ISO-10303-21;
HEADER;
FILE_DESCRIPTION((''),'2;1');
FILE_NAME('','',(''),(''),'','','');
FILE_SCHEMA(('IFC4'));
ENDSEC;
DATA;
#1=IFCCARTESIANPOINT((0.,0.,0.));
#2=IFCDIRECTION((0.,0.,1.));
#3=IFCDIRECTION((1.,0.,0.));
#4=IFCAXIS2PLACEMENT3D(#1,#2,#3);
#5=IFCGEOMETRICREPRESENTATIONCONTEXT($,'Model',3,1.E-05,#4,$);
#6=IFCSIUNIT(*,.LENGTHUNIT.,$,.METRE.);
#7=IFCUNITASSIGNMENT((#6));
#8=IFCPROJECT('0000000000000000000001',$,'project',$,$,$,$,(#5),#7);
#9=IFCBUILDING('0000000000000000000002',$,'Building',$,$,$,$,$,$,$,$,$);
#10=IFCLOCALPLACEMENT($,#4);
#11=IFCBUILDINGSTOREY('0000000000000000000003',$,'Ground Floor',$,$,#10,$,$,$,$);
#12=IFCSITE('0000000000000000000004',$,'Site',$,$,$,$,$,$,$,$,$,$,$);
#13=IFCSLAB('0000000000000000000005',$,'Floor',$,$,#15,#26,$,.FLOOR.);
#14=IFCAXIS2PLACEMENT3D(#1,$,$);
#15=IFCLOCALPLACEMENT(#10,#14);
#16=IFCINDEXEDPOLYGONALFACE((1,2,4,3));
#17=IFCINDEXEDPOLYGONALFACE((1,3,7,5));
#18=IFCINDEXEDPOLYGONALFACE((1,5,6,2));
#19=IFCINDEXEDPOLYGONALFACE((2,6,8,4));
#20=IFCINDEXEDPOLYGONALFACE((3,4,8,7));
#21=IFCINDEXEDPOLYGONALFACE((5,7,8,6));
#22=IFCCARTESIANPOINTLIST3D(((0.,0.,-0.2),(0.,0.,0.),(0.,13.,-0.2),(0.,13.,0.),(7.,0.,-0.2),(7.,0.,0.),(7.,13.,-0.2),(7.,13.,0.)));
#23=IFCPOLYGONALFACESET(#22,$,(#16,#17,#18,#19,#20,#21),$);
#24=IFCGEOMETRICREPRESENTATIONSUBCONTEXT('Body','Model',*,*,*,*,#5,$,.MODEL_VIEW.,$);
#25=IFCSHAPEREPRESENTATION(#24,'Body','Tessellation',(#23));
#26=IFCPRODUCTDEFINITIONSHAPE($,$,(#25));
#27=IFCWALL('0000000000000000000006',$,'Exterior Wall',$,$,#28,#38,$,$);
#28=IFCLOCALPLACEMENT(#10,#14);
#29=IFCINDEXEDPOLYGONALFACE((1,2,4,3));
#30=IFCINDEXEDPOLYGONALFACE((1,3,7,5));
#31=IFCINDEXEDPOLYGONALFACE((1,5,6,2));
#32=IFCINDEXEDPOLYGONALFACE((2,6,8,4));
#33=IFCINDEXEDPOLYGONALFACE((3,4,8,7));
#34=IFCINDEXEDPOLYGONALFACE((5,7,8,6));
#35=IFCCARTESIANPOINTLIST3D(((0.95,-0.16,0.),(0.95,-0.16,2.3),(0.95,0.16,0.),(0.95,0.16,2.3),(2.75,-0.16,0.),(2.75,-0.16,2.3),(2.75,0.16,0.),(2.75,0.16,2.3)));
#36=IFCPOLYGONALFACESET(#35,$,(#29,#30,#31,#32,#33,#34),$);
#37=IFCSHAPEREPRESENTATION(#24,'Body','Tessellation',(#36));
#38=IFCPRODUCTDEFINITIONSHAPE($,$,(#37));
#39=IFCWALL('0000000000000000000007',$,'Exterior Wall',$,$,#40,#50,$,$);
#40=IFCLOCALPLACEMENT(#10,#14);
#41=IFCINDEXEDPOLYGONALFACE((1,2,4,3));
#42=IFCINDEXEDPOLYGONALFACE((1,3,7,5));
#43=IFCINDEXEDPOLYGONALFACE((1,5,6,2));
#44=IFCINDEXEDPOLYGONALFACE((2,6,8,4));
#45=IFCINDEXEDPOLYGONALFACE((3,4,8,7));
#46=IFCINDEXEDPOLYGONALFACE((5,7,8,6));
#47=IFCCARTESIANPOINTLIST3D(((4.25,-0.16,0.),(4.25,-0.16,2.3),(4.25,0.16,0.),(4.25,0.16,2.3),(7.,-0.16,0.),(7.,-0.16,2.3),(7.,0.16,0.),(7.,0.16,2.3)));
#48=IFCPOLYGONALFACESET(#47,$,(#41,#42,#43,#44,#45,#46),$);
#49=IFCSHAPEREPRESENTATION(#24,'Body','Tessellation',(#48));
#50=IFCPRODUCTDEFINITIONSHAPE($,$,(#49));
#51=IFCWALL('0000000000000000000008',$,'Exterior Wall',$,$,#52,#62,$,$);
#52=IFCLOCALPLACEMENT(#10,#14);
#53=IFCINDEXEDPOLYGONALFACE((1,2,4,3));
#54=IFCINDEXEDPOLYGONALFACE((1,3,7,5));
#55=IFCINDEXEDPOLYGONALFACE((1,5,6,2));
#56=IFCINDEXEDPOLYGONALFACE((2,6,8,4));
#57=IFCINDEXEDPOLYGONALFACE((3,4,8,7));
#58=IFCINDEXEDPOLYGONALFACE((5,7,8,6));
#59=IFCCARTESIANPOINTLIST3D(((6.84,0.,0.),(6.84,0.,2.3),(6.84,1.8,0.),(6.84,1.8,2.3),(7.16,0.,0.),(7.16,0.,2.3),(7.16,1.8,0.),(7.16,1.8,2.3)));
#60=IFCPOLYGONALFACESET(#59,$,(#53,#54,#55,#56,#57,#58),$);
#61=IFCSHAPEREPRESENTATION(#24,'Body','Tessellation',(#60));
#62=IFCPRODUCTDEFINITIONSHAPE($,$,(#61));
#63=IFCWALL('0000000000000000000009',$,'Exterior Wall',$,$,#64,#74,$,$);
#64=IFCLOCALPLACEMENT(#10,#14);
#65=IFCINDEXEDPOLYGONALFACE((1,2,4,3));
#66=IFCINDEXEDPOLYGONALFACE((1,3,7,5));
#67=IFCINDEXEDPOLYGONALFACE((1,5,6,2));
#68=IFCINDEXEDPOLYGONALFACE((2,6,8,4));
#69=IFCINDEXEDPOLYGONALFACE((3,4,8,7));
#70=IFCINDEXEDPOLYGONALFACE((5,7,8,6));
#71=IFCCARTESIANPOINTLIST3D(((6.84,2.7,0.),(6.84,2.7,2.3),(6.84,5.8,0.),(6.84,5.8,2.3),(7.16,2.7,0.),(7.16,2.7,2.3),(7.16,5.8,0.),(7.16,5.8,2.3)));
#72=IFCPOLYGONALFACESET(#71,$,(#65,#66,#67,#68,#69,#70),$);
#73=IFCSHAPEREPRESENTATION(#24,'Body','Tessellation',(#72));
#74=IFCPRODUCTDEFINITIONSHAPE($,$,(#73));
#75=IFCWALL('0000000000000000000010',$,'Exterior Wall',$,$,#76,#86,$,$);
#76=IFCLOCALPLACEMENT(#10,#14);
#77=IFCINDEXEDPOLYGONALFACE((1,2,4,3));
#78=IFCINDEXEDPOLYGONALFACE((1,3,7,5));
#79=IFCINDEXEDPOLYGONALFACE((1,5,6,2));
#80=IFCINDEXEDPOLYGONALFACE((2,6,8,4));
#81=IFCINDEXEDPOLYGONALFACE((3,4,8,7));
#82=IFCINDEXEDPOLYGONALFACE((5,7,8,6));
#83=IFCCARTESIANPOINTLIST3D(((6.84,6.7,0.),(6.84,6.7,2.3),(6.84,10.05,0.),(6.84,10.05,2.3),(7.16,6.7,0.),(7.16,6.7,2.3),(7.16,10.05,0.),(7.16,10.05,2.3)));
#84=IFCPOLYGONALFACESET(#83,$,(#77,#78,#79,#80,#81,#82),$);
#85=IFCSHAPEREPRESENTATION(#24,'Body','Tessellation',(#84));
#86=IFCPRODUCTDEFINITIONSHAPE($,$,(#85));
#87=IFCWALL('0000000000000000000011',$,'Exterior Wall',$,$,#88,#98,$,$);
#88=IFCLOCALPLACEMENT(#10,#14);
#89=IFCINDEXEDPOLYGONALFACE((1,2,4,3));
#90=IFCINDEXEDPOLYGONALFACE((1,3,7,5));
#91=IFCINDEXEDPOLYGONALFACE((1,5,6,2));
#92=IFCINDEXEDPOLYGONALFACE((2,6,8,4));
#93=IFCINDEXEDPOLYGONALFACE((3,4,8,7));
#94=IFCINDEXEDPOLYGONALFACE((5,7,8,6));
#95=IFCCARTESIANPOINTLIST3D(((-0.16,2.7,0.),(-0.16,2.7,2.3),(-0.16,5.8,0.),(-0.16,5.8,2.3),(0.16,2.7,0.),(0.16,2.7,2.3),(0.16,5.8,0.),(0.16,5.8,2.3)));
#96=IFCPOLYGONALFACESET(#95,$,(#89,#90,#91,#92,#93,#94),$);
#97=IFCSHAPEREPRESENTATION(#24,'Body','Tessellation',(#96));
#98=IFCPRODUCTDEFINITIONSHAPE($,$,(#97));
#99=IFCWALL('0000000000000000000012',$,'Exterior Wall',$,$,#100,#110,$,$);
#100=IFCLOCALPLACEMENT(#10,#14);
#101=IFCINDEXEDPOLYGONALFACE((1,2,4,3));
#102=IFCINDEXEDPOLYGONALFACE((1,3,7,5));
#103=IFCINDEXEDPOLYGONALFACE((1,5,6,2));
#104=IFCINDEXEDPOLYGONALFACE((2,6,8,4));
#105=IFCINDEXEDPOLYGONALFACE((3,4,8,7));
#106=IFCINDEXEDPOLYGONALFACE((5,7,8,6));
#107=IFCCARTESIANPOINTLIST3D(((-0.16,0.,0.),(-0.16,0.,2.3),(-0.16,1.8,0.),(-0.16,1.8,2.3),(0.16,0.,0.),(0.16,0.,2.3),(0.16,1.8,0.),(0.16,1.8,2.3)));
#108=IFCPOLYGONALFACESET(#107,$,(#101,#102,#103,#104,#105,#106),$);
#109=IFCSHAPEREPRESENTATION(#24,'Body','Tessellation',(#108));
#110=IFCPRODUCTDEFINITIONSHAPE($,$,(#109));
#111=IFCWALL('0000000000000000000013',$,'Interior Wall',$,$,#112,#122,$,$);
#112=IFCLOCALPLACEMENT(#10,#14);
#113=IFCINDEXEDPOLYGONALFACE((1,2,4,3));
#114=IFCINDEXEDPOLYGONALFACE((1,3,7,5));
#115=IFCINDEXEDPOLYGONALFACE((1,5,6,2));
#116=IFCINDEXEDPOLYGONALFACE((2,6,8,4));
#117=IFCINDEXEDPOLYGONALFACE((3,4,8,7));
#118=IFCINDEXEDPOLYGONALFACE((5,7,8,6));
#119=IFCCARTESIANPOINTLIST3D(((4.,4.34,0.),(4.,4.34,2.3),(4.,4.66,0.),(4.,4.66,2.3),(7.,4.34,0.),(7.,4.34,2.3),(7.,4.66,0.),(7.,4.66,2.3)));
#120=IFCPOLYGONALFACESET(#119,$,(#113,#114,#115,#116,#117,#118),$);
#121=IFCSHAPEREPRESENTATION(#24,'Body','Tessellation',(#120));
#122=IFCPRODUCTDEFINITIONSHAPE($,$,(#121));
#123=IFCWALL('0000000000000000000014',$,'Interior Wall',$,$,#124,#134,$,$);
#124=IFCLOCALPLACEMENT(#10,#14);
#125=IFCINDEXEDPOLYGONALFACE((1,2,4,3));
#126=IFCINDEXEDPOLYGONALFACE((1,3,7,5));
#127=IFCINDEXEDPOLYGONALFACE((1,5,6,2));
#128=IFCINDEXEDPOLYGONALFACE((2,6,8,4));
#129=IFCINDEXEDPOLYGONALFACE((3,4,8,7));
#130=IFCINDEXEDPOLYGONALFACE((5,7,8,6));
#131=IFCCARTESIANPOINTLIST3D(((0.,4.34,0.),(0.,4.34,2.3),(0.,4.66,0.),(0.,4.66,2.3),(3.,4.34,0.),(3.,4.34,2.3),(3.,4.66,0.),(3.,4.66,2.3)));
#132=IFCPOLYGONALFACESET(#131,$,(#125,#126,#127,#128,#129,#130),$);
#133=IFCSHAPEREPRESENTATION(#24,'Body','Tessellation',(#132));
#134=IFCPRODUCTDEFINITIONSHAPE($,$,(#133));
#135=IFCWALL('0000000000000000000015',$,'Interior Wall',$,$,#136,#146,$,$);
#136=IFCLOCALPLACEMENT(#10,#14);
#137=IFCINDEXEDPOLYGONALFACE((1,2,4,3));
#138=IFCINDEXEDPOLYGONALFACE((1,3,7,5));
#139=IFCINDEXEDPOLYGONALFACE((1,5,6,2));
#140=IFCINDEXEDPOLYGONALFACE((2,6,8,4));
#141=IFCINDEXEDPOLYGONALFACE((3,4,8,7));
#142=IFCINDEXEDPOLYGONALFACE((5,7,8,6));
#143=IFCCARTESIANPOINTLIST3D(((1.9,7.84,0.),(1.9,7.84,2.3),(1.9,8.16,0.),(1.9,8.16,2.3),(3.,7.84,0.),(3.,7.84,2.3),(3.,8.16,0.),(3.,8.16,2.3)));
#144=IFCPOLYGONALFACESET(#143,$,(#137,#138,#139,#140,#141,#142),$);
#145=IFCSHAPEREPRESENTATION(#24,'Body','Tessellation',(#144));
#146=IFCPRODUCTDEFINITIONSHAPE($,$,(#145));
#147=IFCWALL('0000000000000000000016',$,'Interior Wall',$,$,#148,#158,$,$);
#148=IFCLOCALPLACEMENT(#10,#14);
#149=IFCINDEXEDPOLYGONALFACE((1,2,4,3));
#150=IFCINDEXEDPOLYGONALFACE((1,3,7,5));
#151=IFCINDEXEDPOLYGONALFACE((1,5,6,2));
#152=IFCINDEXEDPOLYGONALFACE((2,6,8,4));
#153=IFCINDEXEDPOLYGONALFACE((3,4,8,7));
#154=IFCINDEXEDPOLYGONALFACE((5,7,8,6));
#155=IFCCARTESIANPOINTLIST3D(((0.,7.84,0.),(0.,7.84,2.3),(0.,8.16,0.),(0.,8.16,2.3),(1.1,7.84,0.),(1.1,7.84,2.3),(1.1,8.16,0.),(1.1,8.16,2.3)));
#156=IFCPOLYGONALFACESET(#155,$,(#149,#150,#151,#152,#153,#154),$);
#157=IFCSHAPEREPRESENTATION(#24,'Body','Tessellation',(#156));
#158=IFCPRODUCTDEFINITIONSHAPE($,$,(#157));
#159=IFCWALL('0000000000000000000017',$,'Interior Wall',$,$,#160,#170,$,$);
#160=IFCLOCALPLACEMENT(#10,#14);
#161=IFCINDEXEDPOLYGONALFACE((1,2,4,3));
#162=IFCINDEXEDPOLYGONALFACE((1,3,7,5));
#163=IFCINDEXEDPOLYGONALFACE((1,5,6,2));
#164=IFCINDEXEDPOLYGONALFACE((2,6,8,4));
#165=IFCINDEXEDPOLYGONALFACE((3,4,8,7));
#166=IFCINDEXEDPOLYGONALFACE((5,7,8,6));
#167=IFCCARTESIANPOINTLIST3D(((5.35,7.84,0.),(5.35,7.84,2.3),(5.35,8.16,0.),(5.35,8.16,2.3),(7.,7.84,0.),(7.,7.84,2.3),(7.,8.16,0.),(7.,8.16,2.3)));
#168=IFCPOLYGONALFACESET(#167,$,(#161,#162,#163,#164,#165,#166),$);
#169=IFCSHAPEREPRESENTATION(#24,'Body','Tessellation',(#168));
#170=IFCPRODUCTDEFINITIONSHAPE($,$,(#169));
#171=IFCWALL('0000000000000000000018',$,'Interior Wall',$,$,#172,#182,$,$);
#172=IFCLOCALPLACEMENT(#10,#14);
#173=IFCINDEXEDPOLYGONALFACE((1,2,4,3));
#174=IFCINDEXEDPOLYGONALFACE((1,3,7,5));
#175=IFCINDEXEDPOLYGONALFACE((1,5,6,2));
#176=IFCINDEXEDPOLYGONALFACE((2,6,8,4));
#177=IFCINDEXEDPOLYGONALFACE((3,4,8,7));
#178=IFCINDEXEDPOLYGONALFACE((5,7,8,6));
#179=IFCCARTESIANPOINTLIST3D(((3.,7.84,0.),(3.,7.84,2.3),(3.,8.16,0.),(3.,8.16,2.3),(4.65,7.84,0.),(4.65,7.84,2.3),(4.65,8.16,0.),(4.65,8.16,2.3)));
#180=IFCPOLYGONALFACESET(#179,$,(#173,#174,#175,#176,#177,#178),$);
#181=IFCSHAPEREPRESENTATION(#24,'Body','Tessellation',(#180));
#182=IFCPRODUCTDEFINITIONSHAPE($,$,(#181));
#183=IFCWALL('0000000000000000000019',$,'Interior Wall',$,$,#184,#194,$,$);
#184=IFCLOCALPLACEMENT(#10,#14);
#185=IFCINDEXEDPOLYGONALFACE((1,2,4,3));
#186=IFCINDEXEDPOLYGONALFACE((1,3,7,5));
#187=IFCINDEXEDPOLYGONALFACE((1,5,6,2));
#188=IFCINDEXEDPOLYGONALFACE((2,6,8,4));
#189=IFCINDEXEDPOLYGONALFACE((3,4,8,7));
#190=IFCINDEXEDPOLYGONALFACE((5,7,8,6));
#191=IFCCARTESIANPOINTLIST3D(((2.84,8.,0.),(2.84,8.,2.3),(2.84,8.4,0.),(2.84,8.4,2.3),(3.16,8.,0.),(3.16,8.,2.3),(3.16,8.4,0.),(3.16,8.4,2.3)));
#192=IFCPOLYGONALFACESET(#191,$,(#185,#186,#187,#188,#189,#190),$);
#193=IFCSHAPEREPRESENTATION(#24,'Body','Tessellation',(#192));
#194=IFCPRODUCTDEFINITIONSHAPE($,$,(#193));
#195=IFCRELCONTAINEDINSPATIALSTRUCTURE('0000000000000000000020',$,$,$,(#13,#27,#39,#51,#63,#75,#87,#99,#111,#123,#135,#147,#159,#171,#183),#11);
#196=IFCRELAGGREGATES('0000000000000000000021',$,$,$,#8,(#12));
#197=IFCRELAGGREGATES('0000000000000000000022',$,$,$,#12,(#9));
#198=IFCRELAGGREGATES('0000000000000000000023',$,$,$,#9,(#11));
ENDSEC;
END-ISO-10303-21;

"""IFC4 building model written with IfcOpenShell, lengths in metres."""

from ifc_helpers import new_model, si_unit, frame, origin_with_axes, place, context, subcontext, project, spatial, indexed_curve, outline, extrude, element, save


model = new_model("IFC4")

# Units and contexts
model_context = context("Model", 3, precision=1e-05, world=origin_with_axes())
body_context = subcontext(model_context, "Body", "Model", "MODEL_VIEW")
ifc_project = project(units=[si_unit("LENGTHUNIT", "METRE")], contexts=[model_context])

# Site, building, storey
site = spatial("IfcSite", under=ifc_project, Name="Site")
building = spatial("IfcBuilding", under=site, Name="Building")
storey_placement = place(None, origin_with_axes())
storey = spatial("IfcBuildingStorey", under=building, at=storey_placement, Name="Ground Floor")

# Slab
slab_placement = place(storey_placement, frame((0.0, 0.0, -0.2), z_axis=(0.0, 0.0, 1.0), x_axis=(1.0, 0.0, 0.0)))
element("IfcSlab", 1, at=slab_placement, inside=storey, Name="Floor", PredefinedType="FLOOR", context=body_context, shape_type="SweptSolid", body=[
    extrude(outline(indexed_curve([(0.0, 0.0), (7.0, 0.0), (7.0, 13.0), (0.0, 13.0)])), None, (0.0, 0.0, 1.0), 0.2),
])

# Walls
wall_1_placement = place(storey_placement, frame((0.95, 0.0, 0.0), z_axis=(0.0, 0.0, 1.0), x_axis=(1.0, 0.0, 0.0)))
element("IfcWall", 2, at=wall_1_placement, inside=storey, Name="Exterior Wall", context=body_context, shape_type="SweptSolid", body=[
    extrude(outline(indexed_curve([(0.0, 0.0), (0.0, 0.32), (1.8, 0.32), (1.8, 0.0), (0.0, 0.0)], self_intersect=False)), frame((0.0, -0.16, 0.0), z_axis=(0.0, 0.0, 1.0), x_axis=(1.0, 0.0, 0.0)), (0.0, 0.0, 1.0), 2.3),
])
wall_2_placement = place(storey_placement, frame((4.25, 0.0, 0.0), z_axis=(0.0, 0.0, 1.0), x_axis=(1.0, 0.0, 0.0)))
element("IfcWall", 3, at=wall_2_placement, inside=storey, Name="Exterior Wall", context=body_context, shape_type="SweptSolid", body=[
    extrude(outline(indexed_curve([(0.0, 0.0), (0.0, 0.32), (2.75, 0.32), (2.75, 0.0), (0.0, 0.0)], self_intersect=False)), frame((0.0, -0.16, 0.0), z_axis=(0.0, 0.0, 1.0), x_axis=(1.0, 0.0, 0.0)), (0.0, 0.0, 1.0), 2.3),
])
wall_3_placement = place(storey_placement, frame((7.0, 0.0, 0.0), z_axis=(0.0, 0.0, 1.0), x_axis=(0.0, 1.0, 0.0)))
element("IfcWall", 4, at=wall_3_placement, inside=storey, Name="Exterior Wall", context=body_context, shape_type="SweptSolid", body=[
    extrude(outline(indexed_curve([(0.0, 0.0), (0.0, 0.32), (1.8, 0.32), (1.8, 0.0), (0.0, 0.0)], self_intersect=False)), frame((0.0, -0.16, 0.0), z_axis=(0.0, 0.0, 1.0), x_axis=(1.0, 0.0, 0.0)), (0.0, 0.0, 1.0), 2.3),
])
wall_4_placement = place(storey_placement, frame((7.0, 2.7, 0.0), z_axis=(0.0, 0.0, 1.0), x_axis=(0.0, 1.0, 0.0)))
element("IfcWall", 5, at=wall_4_placement, inside=storey, Name="Exterior Wall", context=body_context, shape_type="SweptSolid", body=[
    extrude(outline(indexed_curve([(0.0, 0.0), (0.0, 0.32), (3.1, 0.32), (3.1, 0.0), (0.0, 0.0)], self_intersect=False)), frame((0.0, -0.16, 0.0), z_axis=(0.0, 0.0, 1.0), x_axis=(1.0, 0.0, 0.0)), (0.0, 0.0, 1.0), 2.3),
])
wall_5_placement = place(storey_placement, frame((7.0, 6.7, 0.0), z_axis=(0.0, 0.0, 1.0), x_axis=(0.0, 1.0, 0.0)))
element("IfcWall", 6, at=wall_5_placement, inside=storey, Name="Exterior Wall", context=body_context, shape_type="SweptSolid", body=[
    extrude(outline(indexed_curve([(0.0, 0.0), (0.0, 0.32), (3.35, 0.32), (3.35, 0.0), (0.0, 0.0)], self_intersect=False)), frame((0.0, -0.16, 0.0), z_axis=(0.0, 0.0, 1.0), x_axis=(1.0, 0.0, 0.0)), (0.0, 0.0, 1.0), 2.3),
])
wall_6_placement = place(storey_placement, frame((0.0, 5.8, 0.0), z_axis=(0.0, 0.0, 1.0), x_axis=(0.0, -1.0, 0.0)))
element("IfcWall", 7, at=wall_6_placement, inside=storey, Name="Exterior Wall", context=body_context, shape_type="SweptSolid", body=[
    extrude(outline(indexed_curve([(0.0, 0.0), (0.0, 0.32), (3.1, 0.32), (3.1, 0.0), (0.0, 0.0)], self_intersect=False)), frame((0.0, -0.16, 0.0), z_axis=(0.0, 0.0, 1.0), x_axis=(1.0, 0.0, 0.0)), (0.0, 0.0, 1.0), 2.3),
])
wall_7_placement = place(storey_placement, frame((0.0, 1.8, 0.0), z_axis=(0.0, 0.0, 1.0), x_axis=(0.0, -1.0, 0.0)))
element("IfcWall", 8, at=wall_7_placement, inside=storey, Name="Exterior Wall", context=body_context, shape_type="SweptSolid", body=[
    extrude(outline(indexed_curve([(0.0, 0.0), (0.0, 0.32), (1.8, 0.32), (1.8, 0.0), (0.0, 0.0)], self_intersect=False)), frame((0.0, -0.16, 0.0), z_axis=(0.0, 0.0, 1.0), x_axis=(1.0, 0.0, 0.0)), (0.0, 0.0, 1.0), 2.3),
])
for number, where, z_axis, x_axis, name in (
    (9, (7.0, 4.5, 0.0), (0.0, 0.0, 1.0), (-1.0, 0.0, 0.0), "Interior Wall"),
    (10, (3.0, 4.5, 0.0), (0.0, 0.0, 1.0), (-1.0, 0.0, 0.0), "Interior Wall"),
):
    element("IfcWall", number, at=place(storey_placement, frame(where, z_axis=z_axis, x_axis=x_axis)), inside=storey, Name=name, context=body_context, shape_type="SweptSolid", body=[
        extrude(outline(indexed_curve([(0.0, 0.0), (0.0, 0.32), (3.0, 0.32), (3.0, 0.0), (0.0, 0.0)], self_intersect=False)), frame((0.0, -0.16, 0.0), z_axis=(0.0, 0.0, 1.0), x_axis=(1.0, 0.0, 0.0)), (0.0, 0.0, 1.0), 2.3),
    ])
for number, where, z_axis, x_axis, name in (
    (11, (3.0, 8.0, 0.0), (0.0, 0.0, 1.0), (-1.0, 0.0, 0.0), "Interior Wall"),
    (12, (1.1, 8.0, 0.0), (0.0, 0.0, 1.0), (-1.0, 0.0, 0.0), "Interior Wall"),
):
    element("IfcWall", number, at=place(storey_placement, frame(where, z_axis=z_axis, x_axis=x_axis)), inside=storey, Name=name, context=body_context, shape_type="SweptSolid", body=[
        extrude(outline(indexed_curve([(0.0, 0.0), (0.0, 0.32), (1.1, 0.32), (1.1, 0.0), (0.0, 0.0)], self_intersect=False)), frame((0.0, -0.16, 0.0), z_axis=(0.0, 0.0, 1.0), x_axis=(1.0, 0.0, 0.0)), (0.0, 0.0, 1.0), 2.3),
    ])
for number, where, z_axis, x_axis, name in (
    (13, (7.0, 8.0, 0.0), (0.0, 0.0, 1.0), (-1.0, 0.0, 0.0), "Interior Wall"),
    (14, (4.65, 8.0, 0.0), (0.0, 0.0, 1.0), (-1.0, 0.0, 0.0), "Interior Wall"),
):
    element("IfcWall", number, at=place(storey_placement, frame(where, z_axis=z_axis, x_axis=x_axis)), inside=storey, Name=name, context=body_context, shape_type="SweptSolid", body=[
        extrude(outline(indexed_curve([(0.0, 0.0), (0.0, 0.32), (1.65, 0.32), (1.65, 0.0), (0.0, 0.0)], self_intersect=False)), frame((0.0, -0.16, 0.0), z_axis=(0.0, 0.0, 1.0), x_axis=(1.0, 0.0, 0.0)), (0.0, 0.0, 1.0), 2.3),
    ])
wall_8_placement = place(storey_placement, frame((3.0, 8.0, 0.0), z_axis=(0.0, 0.0, 1.0), x_axis=(0.0, 1.0, 0.0)))
element("IfcWall", 15, at=wall_8_placement, inside=storey, Name="Interior Wall", context=body_context, shape_type="SweptSolid", body=[
    extrude(outline(indexed_curve([(0.0, 0.0), (0.0, 0.32), (0.4, 0.32), (0.4, 0.0), (0.0, 0.0)], self_intersect=False)), frame((0.0, -0.16, 0.0), z_axis=(0.0, 0.0, 1.0), x_axis=(1.0, 0.0, 0.0)), (0.0, 0.0, 1.0), 2.3),
])

save(model, "model.ifc")
